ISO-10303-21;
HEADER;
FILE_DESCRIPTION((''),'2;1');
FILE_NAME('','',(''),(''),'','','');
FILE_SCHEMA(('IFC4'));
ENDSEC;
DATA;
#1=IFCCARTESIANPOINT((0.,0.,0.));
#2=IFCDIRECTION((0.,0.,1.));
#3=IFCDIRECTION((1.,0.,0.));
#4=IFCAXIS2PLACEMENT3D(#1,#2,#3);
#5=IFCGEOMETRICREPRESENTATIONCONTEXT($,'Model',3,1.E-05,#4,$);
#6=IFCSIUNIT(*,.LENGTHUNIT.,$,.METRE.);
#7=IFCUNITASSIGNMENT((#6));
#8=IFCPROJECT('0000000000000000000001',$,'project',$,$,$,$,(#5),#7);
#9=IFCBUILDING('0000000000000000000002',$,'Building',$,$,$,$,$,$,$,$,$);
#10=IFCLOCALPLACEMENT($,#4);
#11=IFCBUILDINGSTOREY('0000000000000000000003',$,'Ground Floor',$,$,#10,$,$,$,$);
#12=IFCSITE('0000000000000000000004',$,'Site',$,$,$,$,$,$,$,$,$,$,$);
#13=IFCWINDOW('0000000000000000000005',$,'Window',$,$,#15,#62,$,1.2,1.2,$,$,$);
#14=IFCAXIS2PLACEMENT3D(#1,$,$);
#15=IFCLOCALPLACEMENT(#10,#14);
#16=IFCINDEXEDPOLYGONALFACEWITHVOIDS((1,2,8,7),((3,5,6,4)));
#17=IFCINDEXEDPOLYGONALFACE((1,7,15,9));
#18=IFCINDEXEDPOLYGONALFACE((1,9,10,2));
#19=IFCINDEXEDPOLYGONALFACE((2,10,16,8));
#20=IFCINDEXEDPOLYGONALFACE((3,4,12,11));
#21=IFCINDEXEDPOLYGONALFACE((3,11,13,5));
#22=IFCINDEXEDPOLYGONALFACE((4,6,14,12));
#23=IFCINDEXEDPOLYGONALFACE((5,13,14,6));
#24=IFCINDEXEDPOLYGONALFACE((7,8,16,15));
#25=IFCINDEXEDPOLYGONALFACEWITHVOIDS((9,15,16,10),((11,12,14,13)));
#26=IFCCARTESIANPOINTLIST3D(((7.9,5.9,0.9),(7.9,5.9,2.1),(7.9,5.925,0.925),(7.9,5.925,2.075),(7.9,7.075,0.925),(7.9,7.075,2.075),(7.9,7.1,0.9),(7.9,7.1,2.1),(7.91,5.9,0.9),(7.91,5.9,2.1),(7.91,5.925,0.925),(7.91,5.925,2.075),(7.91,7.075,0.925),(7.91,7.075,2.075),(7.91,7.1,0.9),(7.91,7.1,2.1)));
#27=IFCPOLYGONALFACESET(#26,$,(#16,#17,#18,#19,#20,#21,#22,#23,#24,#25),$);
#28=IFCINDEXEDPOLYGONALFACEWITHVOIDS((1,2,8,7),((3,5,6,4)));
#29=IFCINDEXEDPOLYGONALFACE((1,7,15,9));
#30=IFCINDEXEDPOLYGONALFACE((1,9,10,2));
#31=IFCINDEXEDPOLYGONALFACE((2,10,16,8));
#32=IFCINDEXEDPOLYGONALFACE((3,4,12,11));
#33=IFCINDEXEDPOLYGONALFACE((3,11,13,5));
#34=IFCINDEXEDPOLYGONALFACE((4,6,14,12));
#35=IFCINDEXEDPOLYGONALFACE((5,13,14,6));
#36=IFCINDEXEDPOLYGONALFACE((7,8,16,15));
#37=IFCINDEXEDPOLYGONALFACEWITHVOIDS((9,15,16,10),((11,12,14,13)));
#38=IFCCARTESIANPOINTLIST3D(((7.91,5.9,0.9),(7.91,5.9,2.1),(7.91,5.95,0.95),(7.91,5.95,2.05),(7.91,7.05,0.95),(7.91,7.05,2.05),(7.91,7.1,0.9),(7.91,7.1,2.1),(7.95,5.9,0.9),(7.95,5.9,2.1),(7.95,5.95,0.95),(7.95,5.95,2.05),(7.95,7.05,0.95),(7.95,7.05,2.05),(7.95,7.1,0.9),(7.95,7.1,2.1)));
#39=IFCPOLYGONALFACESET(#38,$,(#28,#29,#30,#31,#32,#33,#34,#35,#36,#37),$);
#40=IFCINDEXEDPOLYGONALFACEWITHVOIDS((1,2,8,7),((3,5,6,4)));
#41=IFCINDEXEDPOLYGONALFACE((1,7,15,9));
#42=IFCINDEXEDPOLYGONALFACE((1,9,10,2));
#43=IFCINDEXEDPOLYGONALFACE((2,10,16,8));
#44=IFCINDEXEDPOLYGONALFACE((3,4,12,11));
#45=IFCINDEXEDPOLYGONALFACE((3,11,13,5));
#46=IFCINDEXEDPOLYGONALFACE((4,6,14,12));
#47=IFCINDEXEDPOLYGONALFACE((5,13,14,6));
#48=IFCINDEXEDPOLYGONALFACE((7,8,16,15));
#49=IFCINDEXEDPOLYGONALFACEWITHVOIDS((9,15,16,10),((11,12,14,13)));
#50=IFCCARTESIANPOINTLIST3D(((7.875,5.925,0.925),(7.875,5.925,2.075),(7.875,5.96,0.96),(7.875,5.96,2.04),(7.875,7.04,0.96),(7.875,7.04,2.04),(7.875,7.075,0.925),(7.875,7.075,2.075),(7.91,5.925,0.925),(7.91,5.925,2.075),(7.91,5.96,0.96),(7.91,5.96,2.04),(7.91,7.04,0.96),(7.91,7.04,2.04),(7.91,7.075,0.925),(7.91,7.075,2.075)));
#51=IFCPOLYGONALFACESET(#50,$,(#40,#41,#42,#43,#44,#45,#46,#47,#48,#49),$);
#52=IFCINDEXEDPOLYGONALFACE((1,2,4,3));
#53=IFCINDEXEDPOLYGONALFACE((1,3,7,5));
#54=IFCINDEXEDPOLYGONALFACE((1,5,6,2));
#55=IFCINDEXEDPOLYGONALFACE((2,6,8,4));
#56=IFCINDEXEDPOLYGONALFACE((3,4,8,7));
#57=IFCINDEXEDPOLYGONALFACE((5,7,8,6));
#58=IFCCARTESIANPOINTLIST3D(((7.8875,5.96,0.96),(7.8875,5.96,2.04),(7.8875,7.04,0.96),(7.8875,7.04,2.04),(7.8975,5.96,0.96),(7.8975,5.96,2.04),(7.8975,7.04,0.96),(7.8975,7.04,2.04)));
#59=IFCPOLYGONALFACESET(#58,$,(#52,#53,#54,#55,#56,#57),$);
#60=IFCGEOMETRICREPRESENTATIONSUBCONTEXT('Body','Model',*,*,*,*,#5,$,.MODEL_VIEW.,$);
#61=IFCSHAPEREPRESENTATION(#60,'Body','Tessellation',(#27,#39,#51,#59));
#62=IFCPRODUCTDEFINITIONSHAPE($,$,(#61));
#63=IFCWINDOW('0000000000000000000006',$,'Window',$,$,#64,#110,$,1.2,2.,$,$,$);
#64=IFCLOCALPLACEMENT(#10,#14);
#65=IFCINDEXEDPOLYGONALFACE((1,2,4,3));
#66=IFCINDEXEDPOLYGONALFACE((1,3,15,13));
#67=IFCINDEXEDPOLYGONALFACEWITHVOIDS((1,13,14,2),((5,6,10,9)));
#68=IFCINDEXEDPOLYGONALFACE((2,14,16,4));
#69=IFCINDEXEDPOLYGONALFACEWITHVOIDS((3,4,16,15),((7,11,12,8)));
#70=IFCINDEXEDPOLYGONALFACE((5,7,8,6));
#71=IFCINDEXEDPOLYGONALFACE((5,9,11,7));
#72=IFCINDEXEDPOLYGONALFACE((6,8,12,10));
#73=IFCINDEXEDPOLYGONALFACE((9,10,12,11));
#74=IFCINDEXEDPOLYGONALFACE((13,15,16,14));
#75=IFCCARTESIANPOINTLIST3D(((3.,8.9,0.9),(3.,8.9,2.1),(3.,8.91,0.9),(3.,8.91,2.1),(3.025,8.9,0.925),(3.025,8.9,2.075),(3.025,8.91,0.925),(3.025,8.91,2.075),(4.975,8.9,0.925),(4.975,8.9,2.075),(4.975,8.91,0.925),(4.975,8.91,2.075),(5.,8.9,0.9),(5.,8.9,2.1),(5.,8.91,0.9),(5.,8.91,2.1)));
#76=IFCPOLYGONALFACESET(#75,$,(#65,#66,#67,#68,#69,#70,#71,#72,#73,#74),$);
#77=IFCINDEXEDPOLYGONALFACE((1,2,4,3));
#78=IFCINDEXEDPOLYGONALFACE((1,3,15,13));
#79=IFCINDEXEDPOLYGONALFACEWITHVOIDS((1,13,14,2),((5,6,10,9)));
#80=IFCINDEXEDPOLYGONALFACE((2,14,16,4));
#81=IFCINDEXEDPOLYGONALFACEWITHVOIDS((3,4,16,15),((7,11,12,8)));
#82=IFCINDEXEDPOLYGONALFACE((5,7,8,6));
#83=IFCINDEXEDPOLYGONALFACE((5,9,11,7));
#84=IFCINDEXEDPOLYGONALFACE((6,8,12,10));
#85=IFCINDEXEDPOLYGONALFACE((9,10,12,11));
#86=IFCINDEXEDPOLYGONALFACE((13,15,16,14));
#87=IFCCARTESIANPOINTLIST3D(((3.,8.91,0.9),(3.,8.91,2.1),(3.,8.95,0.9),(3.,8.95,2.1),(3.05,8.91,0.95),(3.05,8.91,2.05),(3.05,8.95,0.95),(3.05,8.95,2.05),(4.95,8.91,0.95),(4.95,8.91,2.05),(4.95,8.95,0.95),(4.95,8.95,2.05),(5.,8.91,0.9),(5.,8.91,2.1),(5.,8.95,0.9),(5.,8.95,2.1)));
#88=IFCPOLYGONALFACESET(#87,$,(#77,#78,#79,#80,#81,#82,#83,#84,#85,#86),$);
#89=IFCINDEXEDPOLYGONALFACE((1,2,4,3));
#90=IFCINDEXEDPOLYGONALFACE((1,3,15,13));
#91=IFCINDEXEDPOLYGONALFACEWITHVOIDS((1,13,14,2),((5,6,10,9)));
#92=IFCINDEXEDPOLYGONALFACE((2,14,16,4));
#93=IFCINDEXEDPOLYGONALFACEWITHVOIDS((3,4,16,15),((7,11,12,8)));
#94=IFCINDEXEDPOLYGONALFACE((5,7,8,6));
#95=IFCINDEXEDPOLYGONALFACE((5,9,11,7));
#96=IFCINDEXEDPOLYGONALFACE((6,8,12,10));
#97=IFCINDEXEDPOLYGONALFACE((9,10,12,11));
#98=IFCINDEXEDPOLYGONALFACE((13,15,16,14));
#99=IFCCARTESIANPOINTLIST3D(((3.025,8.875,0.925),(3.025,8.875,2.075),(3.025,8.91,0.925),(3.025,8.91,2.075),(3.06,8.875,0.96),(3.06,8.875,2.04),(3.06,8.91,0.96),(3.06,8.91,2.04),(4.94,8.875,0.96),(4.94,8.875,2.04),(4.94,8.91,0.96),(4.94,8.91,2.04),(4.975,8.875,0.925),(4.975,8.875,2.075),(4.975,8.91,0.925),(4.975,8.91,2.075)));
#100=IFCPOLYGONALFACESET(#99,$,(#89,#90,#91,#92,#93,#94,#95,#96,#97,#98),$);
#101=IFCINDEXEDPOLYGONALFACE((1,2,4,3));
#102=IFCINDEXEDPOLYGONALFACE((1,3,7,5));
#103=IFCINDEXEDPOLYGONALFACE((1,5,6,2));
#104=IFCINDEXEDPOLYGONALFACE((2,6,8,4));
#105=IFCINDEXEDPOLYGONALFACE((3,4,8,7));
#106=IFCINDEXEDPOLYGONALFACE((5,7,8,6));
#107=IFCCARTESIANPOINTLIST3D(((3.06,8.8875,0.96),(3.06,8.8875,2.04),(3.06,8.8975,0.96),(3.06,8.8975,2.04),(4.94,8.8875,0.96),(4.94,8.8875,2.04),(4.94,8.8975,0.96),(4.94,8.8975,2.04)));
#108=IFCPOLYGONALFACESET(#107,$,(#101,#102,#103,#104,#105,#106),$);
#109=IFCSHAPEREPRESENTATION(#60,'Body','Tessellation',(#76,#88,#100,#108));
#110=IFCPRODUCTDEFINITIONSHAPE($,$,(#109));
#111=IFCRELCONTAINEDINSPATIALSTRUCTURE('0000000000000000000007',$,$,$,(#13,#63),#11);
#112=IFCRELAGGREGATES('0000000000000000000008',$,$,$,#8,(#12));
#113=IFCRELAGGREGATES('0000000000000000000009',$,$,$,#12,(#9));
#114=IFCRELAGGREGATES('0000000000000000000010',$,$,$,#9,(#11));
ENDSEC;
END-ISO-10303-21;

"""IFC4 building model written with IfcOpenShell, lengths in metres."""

from ifc_helpers import new_model, si_unit, frame, origin_with_axes, place, context, subcontext, project, spatial, line, indexed_curve, outline, extrude, element, save


model = new_model("IFC4")

# Units and contexts
model_context = context("Model", 3, precision=1e-05, world=origin_with_axes())
body_context = subcontext(model_context, "Body", "Model", "MODEL_VIEW")
ifc_project = project(units=[si_unit("LENGTHUNIT", "METRE")], contexts=[model_context])

# Site, building, storey
site = spatial("IfcSite", under=ifc_project, Name="Site")
building = spatial("IfcBuilding", under=site, Name="Building")
storey_placement = place(None, origin_with_axes())
storey = spatial("IfcBuildingStorey", under=building, at=storey_placement, Name="Ground Floor")

# Windows
window_1_placement = place(storey_placement, frame((8.0, 5.9, 0.9), z_axis=(0.0, 0.0, 1.0), x_axis=(0.0, 1.0, 0.0)))
element("IfcWindow", 1, at=window_1_placement, inside=storey, Name="Window", OverallHeight=1.2, OverallWidth=1.2, context=body_context, shape_type="SweptSolid", body=[
    extrude(outline(indexed_curve([(0.0, 0.0), (1.2, 0.0), (1.2, 1.2), (0.0, 1.2)], segments=[line(1, 2, 3, 4, 1)]), holes=[indexed_curve([(0.025, 0.025), (1.175, 0.025), (1.175, 1.175), (0.025, 1.175)], segments=[line(1, 2, 3, 4, 1)])]), frame((0.0, 0.09, 0.0), z_axis=(0.0, -1.0, 0.0), x_axis=(1.0, 0.0, 0.0)), (0.0, 0.0, -1.0), 0.01),
    extrude(outline(indexed_curve([(0.0, 0.0), (1.2, 0.0), (1.2, 1.2), (0.0, 1.2)], segments=[line(1, 2, 3, 4, 1)]), holes=[indexed_curve([(0.05, 0.05), (1.15, 0.05), (1.15, 1.15), (0.05, 1.15)], segments=[line(1, 2, 3, 4, 1)])]), frame((0.0, 0.05, 0.0), z_axis=(0.0, -1.0, 0.0), x_axis=(1.0, 0.0, 0.0)), (0.0, 0.0, -1.0), 0.04),
    extrude(outline(indexed_curve([(0.0, 0.0), (1.15, 0.0), (1.15, 1.15), (0.0, 1.15)], segments=[line(1, 2, 3, 4, 1)]), holes=[indexed_curve([(0.035, 0.035), (1.115, 0.035), (1.115, 1.115), (0.035, 1.115)], segments=[line(1, 2, 3, 4, 1)])]), frame((0.025, 0.09, 0.025), z_axis=(0.0, -1.0, 0.0), x_axis=(1.0, 0.0, 0.0)), (0.0, 0.0, -1.0), 0.035),
    extrude(outline(indexed_curve([(0.035, 0.035), (1.115, 0.035), (1.115, 1.115), (0.035, 1.115)], segments=[line(1, 2, 3, 4, 1)])), frame((0.025, 0.1025, 0.025), z_axis=(0.0, -1.0, 0.0), x_axis=(1.0, 0.0, 0.0)), (0.0, 0.0, -1.0), 0.01),
])
window_2_placement = place(storey_placement, frame((5.0, 9.0, 0.9), z_axis=(0.0, 0.0, 1.0), x_axis=(-1.0, 0.0, 0.0)))
element("IfcWindow", 2, at=window_2_placement, inside=storey, Name="Window", OverallHeight=1.2, OverallWidth=2.0, context=body_context, shape_type="SweptSolid", body=[
    extrude(outline(indexed_curve([(0.0, 0.0), (2.0, 0.0), (2.0, 1.2), (0.0, 1.2)], segments=[line(1, 2, 3, 4, 1)]), holes=[indexed_curve([(0.025, 0.025), (1.975, 0.025), (1.975, 1.175), (0.025, 1.175)], segments=[line(1, 2, 3, 4, 1)])]), frame((0.0, 0.09, 0.0), z_axis=(0.0, -1.0, 0.0), x_axis=(1.0, 0.0, 0.0)), (0.0, 0.0, -1.0), 0.01),
    extrude(outline(indexed_curve([(0.0, 0.0), (2.0, 0.0), (2.0, 1.2), (0.0, 1.2)], segments=[line(1, 2, 3, 4, 1)]), holes=[indexed_curve([(0.05, 0.05), (1.95, 0.05), (1.95, 1.15), (0.05, 1.15)], segments=[line(1, 2, 3, 4, 1)])]), frame((0.0, 0.05, 0.0), z_axis=(0.0, -1.0, 0.0), x_axis=(1.0, 0.0, 0.0)), (0.0, 0.0, -1.0), 0.04),
    extrude(outline(indexed_curve([(0.0, 0.0), (1.95, 0.0), (1.95, 1.15), (0.0, 1.15)], segments=[line(1, 2, 3, 4, 1)]), holes=[indexed_curve([(0.035, 0.035), (1.915, 0.035), (1.915, 1.115), (0.035, 1.115)], segments=[line(1, 2, 3, 4, 1)])]), frame((0.025, 0.09, 0.025), z_axis=(0.0, -1.0, 0.0), x_axis=(1.0, 0.0, 0.0)), (0.0, 0.0, -1.0), 0.035),
    extrude(outline(indexed_curve([(0.035, 0.035), (1.915, 0.035), (1.915, 1.115), (0.035, 1.115)], segments=[line(1, 2, 3, 4, 1)])), frame((0.025, 0.1025, 0.025), z_axis=(0.0, -1.0, 0.0), x_axis=(1.0, 0.0, 0.0)), (0.0, 0.0, -1.0), 0.01),
])

save(model, "model.ifc")
